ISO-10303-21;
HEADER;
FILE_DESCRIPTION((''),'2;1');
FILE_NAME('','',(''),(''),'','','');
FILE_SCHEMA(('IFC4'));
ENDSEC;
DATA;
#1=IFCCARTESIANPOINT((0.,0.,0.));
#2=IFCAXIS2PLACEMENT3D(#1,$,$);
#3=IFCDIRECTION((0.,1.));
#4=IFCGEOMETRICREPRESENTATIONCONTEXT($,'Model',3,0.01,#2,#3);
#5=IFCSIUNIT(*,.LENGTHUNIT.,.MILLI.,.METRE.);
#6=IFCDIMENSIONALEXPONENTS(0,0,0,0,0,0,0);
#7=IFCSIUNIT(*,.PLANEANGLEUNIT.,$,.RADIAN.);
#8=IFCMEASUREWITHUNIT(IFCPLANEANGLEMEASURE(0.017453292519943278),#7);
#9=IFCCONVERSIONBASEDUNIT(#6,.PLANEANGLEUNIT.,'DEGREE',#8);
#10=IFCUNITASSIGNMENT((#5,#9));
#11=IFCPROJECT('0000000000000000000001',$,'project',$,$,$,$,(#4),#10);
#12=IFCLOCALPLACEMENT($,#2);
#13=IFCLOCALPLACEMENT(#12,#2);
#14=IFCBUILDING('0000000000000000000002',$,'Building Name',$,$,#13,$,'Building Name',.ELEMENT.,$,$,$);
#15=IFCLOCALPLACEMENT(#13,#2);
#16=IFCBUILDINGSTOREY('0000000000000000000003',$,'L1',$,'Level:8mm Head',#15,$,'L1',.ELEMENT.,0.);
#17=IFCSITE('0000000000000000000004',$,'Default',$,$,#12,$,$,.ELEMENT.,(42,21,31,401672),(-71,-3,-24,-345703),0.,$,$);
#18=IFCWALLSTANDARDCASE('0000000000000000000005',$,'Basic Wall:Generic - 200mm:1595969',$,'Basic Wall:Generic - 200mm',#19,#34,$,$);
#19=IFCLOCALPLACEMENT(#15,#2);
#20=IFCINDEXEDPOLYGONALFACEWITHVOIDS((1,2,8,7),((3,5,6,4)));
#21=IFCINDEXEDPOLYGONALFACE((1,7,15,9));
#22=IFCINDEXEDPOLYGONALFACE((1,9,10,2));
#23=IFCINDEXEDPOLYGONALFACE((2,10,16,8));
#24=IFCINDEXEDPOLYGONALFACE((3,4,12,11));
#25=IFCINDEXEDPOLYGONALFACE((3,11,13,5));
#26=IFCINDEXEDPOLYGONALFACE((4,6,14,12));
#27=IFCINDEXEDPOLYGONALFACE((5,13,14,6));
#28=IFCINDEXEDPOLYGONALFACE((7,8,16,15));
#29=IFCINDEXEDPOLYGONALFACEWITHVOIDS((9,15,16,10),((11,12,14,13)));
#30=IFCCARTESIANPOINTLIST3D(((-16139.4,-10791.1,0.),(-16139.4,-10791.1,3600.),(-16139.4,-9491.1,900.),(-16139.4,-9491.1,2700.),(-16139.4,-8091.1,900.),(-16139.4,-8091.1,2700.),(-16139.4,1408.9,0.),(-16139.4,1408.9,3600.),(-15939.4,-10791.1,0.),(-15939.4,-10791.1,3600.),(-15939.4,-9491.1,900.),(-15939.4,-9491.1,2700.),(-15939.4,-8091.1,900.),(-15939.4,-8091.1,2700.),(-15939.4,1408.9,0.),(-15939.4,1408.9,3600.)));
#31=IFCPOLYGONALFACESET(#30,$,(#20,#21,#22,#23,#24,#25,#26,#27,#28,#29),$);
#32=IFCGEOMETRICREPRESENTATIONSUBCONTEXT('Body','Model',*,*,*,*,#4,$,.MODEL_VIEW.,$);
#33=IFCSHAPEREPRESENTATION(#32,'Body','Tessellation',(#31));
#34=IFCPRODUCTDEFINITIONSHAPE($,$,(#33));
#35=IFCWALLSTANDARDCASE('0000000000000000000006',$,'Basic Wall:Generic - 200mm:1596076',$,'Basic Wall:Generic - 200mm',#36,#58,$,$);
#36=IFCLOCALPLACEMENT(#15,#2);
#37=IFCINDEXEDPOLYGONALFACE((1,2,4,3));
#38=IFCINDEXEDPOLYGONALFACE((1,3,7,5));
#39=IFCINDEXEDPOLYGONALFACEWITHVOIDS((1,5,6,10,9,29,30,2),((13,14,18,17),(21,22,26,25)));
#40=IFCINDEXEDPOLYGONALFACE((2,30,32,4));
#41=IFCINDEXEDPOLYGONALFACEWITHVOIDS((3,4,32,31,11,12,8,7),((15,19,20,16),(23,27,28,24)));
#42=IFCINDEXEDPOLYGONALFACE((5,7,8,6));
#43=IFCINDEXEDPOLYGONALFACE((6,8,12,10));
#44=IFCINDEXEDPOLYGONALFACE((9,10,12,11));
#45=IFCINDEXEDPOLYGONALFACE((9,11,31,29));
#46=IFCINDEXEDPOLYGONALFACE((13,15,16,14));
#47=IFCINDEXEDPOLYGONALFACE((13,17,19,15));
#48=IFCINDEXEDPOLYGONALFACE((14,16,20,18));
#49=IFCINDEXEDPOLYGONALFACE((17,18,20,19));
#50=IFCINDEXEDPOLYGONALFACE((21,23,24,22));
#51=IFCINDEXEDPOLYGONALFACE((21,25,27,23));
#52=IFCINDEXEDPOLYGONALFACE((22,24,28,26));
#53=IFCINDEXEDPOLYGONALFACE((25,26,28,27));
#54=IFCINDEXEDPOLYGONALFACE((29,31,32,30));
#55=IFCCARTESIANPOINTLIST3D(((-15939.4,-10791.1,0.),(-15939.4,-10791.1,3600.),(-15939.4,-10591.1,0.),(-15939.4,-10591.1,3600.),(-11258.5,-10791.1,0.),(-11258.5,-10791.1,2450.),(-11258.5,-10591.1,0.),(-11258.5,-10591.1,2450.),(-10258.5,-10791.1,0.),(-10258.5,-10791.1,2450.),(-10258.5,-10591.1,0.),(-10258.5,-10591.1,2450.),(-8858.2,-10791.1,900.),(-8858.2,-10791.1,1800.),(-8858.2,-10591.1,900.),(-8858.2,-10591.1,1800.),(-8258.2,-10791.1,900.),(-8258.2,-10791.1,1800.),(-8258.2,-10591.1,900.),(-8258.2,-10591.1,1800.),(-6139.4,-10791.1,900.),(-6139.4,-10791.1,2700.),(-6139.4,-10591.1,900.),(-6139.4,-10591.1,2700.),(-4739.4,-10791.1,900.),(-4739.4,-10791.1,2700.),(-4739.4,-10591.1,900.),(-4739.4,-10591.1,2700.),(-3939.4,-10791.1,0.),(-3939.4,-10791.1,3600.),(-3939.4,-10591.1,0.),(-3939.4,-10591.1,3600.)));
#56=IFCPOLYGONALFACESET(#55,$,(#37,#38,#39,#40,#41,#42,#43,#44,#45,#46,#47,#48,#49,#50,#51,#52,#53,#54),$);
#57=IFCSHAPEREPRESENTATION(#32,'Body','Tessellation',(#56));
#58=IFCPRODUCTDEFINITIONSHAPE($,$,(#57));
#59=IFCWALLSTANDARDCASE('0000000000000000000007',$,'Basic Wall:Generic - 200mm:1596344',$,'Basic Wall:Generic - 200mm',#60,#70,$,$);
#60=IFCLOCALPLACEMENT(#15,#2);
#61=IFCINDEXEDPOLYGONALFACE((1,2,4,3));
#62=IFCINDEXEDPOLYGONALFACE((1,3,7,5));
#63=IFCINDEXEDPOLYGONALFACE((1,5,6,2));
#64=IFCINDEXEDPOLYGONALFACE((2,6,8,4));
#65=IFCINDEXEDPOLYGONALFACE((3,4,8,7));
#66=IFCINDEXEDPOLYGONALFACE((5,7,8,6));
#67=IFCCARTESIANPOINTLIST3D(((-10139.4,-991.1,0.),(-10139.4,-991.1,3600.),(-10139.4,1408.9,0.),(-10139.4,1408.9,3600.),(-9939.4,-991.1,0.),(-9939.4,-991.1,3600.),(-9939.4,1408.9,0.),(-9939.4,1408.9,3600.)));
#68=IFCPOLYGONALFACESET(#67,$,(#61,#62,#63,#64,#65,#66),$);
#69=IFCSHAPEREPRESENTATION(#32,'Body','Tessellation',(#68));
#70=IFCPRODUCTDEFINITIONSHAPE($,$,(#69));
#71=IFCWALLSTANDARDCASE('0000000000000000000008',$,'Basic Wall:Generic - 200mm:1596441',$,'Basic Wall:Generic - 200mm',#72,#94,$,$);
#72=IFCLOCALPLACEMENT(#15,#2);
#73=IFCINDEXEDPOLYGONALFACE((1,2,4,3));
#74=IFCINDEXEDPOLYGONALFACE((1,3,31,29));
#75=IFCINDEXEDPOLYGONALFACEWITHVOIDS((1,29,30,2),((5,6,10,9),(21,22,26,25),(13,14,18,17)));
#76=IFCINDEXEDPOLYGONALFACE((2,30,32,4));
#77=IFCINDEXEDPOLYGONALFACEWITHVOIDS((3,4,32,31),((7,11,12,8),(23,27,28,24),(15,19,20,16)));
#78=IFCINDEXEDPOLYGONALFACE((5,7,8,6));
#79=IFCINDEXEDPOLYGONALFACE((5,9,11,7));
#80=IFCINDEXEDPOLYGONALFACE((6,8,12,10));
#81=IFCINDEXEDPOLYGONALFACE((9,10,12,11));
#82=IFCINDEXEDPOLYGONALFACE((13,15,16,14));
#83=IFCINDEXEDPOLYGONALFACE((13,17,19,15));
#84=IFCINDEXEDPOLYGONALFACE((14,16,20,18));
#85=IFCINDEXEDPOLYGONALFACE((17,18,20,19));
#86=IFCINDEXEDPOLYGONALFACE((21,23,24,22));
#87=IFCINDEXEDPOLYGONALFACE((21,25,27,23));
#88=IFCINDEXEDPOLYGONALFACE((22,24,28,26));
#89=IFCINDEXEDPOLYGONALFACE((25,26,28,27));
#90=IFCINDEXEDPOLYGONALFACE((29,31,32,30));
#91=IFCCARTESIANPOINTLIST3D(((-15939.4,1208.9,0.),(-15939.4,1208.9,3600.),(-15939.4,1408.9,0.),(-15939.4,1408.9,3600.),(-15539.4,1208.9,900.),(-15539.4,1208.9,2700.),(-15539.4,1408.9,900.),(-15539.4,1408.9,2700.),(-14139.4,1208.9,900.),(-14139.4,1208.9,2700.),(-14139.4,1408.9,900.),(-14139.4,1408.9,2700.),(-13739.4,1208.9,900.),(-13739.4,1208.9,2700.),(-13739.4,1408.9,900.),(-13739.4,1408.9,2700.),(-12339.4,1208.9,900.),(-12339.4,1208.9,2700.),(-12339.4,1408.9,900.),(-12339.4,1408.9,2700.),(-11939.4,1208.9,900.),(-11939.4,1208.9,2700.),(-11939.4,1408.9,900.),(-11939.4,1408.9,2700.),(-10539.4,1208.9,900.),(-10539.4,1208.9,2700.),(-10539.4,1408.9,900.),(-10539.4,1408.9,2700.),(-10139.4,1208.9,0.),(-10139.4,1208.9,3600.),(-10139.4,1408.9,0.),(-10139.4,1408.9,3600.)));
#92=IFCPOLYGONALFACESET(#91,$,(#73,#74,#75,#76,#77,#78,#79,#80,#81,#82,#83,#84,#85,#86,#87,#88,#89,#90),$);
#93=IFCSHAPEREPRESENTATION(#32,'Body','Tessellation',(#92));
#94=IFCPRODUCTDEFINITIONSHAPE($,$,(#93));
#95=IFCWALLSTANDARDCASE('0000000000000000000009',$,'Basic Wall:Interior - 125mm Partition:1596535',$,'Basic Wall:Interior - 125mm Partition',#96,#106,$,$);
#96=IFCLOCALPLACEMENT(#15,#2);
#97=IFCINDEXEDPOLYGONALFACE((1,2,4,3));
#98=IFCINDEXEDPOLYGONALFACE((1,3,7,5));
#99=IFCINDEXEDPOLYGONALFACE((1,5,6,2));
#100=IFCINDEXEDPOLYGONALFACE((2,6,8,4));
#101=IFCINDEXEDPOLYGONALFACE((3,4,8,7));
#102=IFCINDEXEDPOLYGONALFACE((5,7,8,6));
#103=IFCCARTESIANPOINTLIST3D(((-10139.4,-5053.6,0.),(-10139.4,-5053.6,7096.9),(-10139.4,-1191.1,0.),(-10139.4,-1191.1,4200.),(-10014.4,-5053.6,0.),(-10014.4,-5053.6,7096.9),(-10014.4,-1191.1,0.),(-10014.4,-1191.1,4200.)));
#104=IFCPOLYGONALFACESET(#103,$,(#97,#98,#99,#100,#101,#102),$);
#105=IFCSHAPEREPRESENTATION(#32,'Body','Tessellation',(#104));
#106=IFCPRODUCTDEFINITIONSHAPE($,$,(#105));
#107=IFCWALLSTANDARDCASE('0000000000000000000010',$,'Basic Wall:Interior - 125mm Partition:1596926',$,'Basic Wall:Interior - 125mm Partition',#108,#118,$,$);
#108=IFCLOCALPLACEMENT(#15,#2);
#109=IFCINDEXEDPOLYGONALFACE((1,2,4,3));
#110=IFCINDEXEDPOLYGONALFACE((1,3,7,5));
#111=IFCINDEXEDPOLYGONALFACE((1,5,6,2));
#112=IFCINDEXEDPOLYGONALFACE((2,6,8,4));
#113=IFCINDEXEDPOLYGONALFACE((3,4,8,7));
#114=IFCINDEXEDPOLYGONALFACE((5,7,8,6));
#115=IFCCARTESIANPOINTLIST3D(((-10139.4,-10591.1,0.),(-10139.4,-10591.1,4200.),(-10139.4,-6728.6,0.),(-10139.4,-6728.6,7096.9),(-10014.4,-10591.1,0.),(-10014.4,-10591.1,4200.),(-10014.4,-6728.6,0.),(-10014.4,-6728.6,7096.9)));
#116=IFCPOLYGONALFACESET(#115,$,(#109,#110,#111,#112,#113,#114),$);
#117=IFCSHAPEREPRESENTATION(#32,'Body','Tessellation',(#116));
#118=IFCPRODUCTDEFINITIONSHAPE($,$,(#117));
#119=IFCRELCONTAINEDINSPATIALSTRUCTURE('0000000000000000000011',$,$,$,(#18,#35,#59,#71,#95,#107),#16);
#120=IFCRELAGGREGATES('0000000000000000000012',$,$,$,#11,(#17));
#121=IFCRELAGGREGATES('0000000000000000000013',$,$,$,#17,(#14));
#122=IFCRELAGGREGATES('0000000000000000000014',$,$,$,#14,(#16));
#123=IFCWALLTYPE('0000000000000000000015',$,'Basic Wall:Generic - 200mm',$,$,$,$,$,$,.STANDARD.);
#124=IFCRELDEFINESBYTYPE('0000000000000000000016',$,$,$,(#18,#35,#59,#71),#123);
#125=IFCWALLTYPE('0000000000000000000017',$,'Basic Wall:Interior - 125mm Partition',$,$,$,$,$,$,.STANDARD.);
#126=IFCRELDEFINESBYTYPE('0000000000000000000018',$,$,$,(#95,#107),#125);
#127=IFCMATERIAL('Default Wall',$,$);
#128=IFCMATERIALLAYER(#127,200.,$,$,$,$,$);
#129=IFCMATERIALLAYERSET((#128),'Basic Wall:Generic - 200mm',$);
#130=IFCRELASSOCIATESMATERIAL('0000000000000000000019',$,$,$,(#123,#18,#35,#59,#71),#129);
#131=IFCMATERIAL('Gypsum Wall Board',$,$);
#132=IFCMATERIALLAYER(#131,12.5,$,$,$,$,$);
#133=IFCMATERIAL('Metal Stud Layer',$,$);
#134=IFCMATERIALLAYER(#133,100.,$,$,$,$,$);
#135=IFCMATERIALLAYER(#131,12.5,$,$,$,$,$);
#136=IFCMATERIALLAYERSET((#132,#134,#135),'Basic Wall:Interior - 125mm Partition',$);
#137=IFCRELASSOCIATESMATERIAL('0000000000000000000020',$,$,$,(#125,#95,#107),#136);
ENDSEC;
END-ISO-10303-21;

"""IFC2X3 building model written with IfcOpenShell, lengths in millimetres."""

from ifc_helpers import new_model, entity, si_unit, converted_unit, direction, frame, frame_2d, origin, place, context, subcontext, project, spatial, polyline, rectangle, extrude, clip, bounded_halfspace, material, layer, layer_set, layer_usage, type_object, element, save


model = new_model("IFC2X3")

# Units and contexts
model_context = context("Model", 3, precision=0.01, world=origin(), true_north=direction((0.0, 1.0)))
body_context = subcontext(model_context, "Body", "Model", "MODEL_VIEW")
ifc_project = project(units=[si_unit("LENGTHUNIT", "METRE", prefix="MILLI"), converted_unit("PLANEANGLEUNIT", "DEGREE", entity("IfcPlaneAngleMeasure", 0.017453292519943278), si_unit("PLANEANGLEUNIT", "RADIAN"), dimensions=[0, 0, 0, 0, 0, 0, 0])], contexts=[model_context])

# Site, building, storey
site_placement = place(None, origin())
site = spatial("IfcSite", under=ifc_project, at=site_placement, Name="Default", CompositionType="ELEMENT", RefLatitude=(42, 21, 31, 401672), RefLongitude=(-71, -3, -24, -345703), RefElevation=0.0)
building_placement = place(site_placement, origin())
building = spatial("IfcBuilding", under=site, at=building_placement, Name="Building Name", LongName="Building Name", CompositionType="ELEMENT")
storey_placement = place(building_placement, origin())
storey = spatial("IfcBuildingStorey", under=building, at=storey_placement, Name="L1", ObjectType="Level:8mm Head", LongName="L1", CompositionType="ELEMENT", Elevation=0.0)

# Wall, opening
ifc_material_1 = material(Name="Default Wall")
ifc_layer_1 = layer(ifc_material_1, 200.0)
ifc_layer_set_1 = layer_set([ifc_layer_1], Name="Basic Wall:Generic - 200mm")
ifc_layer_usage_1 = layer_usage(ifc_layer_set_1, "AXIS2", "NEGATIVE", 100.0)
wall_type_1 = type_object("IfcWallType", Name="Basic Wall:Generic - 200mm", PredefinedType="STANDARD", material=ifc_layer_set_1)
wall_1_placement = place(storey_placement, frame((-16039.4, 1408.9, 0.0), z_axis=(0.0, 0.0, 1.0), x_axis=(0.0, -1.0, 0.0)))
wall_1 = element("IfcWallStandardCase", 1, at=wall_1_placement, inside=storey, type_object=wall_type_1, material=ifc_layer_usage_1, Name="Basic Wall:Generic - 200mm:1595969", ObjectType="Basic Wall:Generic - 200mm", context=body_context, shape_type="SweptSolid", body=[
    extrude(rectangle(XDim=12200.0, YDim=200.0, at=frame_2d((6100.0, 0.0), x_axis=(-1.0, 0.0))), origin(), (0.0, 0.0, 1.0), 3600.0),
])
opening_1_placement = place(wall_1_placement, frame((10900.0, 100.0, 900.0)))
element("IfcOpeningElement", 2, at=opening_1_placement, cuts=wall_1, ObjectType="Opening", context=body_context, shape_type="SweptSolid", body=[
    extrude(rectangle(XDim=1800.0, YDim=1400.0, at=frame_2d((900.0, 700.0), x_axis=(-1.0, 0.0))), frame((0.0, 0.0, 0.0), z_axis=(0.0, -1.0, 0.0), x_axis=(0.0, 0.0, 1.0)), (0.0, 0.0, 1.0), 200.0),
])

# Wall, openings
wall_2_placement = place(storey_placement, frame((-15939.4, -10691.1, 0.0)))
wall_2 = element("IfcWallStandardCase", 3, at=wall_2_placement, inside=storey, type_object=wall_type_1, material=ifc_layer_usage_1, Name="Basic Wall:Generic - 200mm:1596076", ObjectType="Basic Wall:Generic - 200mm", context=body_context, shape_type="SweptSolid", body=[
    extrude(rectangle(XDim=12000.0, YDim=200.0, at=frame_2d((6000.0, 0.0), x_axis=(1.0, 0.0))), origin(), (0.0, 0.0, 1.0), 3600.0),
])
opening_2_placement = place(wall_2_placement, frame((4680.9, -100.0, 0.0)))
element("IfcOpeningElement", 4, at=opening_2_placement, cuts=wall_2, ObjectType="Opening", context=body_context, shape_type="SweptSolid", body=[
    extrude(rectangle(XDim=2450.0, YDim=1000.0, at=frame_2d((1225.0, 500.0), x_axis=(1.0, 0.0))), frame((0.0, 0.0, 0.0), z_axis=(0.0, 1.0, 0.0), x_axis=(0.0, 0.0, 1.0)), (0.0, 0.0, 1.0), 200.0),
])
opening_3_placement = place(wall_2_placement, frame((11200.0, 100.0, 900.0)))
element("IfcOpeningElement", 5, at=opening_3_placement, cuts=wall_2, ObjectType="Opening", context=body_context, shape_type="SweptSolid", body=[
    extrude(rectangle(XDim=1800.0, YDim=1400.0, at=frame_2d((900.0, 700.0), x_axis=(-1.0, 0.0))), frame((0.0, 0.0, 0.0), z_axis=(0.0, -1.0, 0.0), x_axis=(0.0, 0.0, 1.0)), (0.0, 0.0, 1.0), 200.0),
])
opening_4_placement = place(wall_2_placement, frame((7081.2, -100.0, 900.0)))
element("IfcOpeningElement", 6, at=opening_4_placement, cuts=wall_2, ObjectType="Opening", context=body_context, shape_type="SweptSolid", body=[
    extrude(rectangle(XDim=900.0, YDim=600.0, at=frame_2d((450.0, 300.0), x_axis=(-1.0, 0.0))), frame((0.0, 0.0, 0.0), z_axis=(0.0, 1.0, 0.0), x_axis=(0.0, 0.0, 1.0)), (0.0, 0.0, 1.0), 200.0),
])

# Wall
wall_3_placement = place(storey_placement, frame((-10039.4, -991.1, 0.0), z_axis=(0.0, 0.0, 1.0), x_axis=(0.0, 1.0, 0.0)))
element("IfcWallStandardCase", 7, at=wall_3_placement, inside=storey, type_object=wall_type_1, material=ifc_layer_usage_1, Name="Basic Wall:Generic - 200mm:1596344", ObjectType="Basic Wall:Generic - 200mm", context=body_context, shape_type="SweptSolid", body=[
    extrude(rectangle(XDim=2400.0, YDim=200.0, at=frame_2d((1200.0, 0.0), x_axis=(-1.0, 0.0))), origin(), (0.0, 0.0, 1.0), 3600.0),
])

# Wall, openings
wall_4_placement = place(storey_placement, frame((-10139.4, 1308.9, 0.0), z_axis=(0.0, 0.0, 1.0), x_axis=(-1.0, 0.0, 0.0)))
wall_4 = element("IfcWallStandardCase", 8, at=wall_4_placement, inside=storey, type_object=wall_type_1, material=ifc_layer_usage_1, Name="Basic Wall:Generic - 200mm:1596441", ObjectType="Basic Wall:Generic - 200mm", context=body_context, shape_type="SweptSolid", body=[
    extrude(rectangle(XDim=5800.0, YDim=200.0, at=frame_2d((2900.0, 0.0), x_axis=(-1.0, 0.0))), origin(), (0.0, 0.0, 1.0), 3600.0),
])
opening_5_placement = place(wall_4_placement, frame((3600.0, 100.0, 900.0)))
element("IfcOpeningElement", 9, at=opening_5_placement, cuts=wall_4, ObjectType="Opening", context=body_context, shape_type="SweptSolid", body=[
    extrude(rectangle(XDim=1800.0, YDim=1400.0, at=frame_2d((900.0, 700.0), x_axis=(-1.0, 0.0))), frame((0.0, 0.0, 0.0), z_axis=(0.0, -1.0, 0.0), x_axis=(0.0, 0.0, 1.0)), (0.0, 0.0, 1.0), 200.0),
])
opening_6_placement = place(wall_4_placement, frame((1800.0, 100.0, 900.0)))
element("IfcOpeningElement", 10, at=opening_6_placement, cuts=wall_4, ObjectType="Opening", context=body_context, shape_type="SweptSolid", body=[
    extrude(rectangle(XDim=1800.0, YDim=1400.0, at=frame_2d((900.0, 700.0), x_axis=(-1.0, 0.0))), frame((0.0, 0.0, 0.0), z_axis=(0.0, -1.0, 0.0), x_axis=(0.0, 0.0, 1.0)), (0.0, 0.0, 1.0), 200.0),
])
opening_7_placement = place(wall_4_placement, frame((5400.0, 100.0, 900.0)))
element("IfcOpeningElement", 11, at=opening_7_placement, cuts=wall_4, ObjectType="Opening", context=body_context, shape_type="SweptSolid", body=[
    extrude(rectangle(XDim=1800.0, YDim=1400.0, at=frame_2d((900.0, 700.0), x_axis=(-1.0, 0.0))), frame((0.0, 0.0, 0.0), z_axis=(0.0, -1.0, 0.0), x_axis=(0.0, 0.0, 1.0)), (0.0, 0.0, 1.0), 200.0),
])

# Walls
ifc_material_2 = material(Name="Gypsum Wall Board")
ifc_layer_2 = layer(ifc_material_2, 12.5)
ifc_material_3 = material(Name="Metal Stud Layer")
ifc_layer_3 = layer(ifc_material_3, 100.0)
ifc_layer_4 = layer(ifc_material_2, 12.5)
ifc_layer_set_2 = layer_set([ifc_layer_2, ifc_layer_3, ifc_layer_4], Name="Basic Wall:Interior - 125mm Partition")
ifc_layer_usage_2 = layer_usage(ifc_layer_set_2, "AXIS2", "NEGATIVE", 62.5)
wall_type_2 = type_object("IfcWallType", Name="Basic Wall:Interior - 125mm Partition", PredefinedType="STANDARD", material=ifc_layer_set_2)
wall_5_placement = place(storey_placement, frame((-10076.9, -1191.1, 0.0), z_axis=(0.0, 0.0, 1.0), x_axis=(0.0, -1.0, 0.0)))
element("IfcWallStandardCase", 12, at=wall_5_placement, inside=storey, type_object=wall_type_2, material=ifc_layer_usage_2, Name="Basic Wall:Interior - 125mm Partition:1596535", ObjectType="Basic Wall:Interior - 125mm Partition", context=body_context, shape_type="Clipping", body=[
    clip(extrude(rectangle(XDim=3862.5, YDim=125.0, at=frame_2d((1931.3, 0.0), x_axis=(-1.0, 0.0))), origin(), (0.0, 0.0, 1.0), 7096.9), bounded_halfspace(frame((0.0, -62.5, 4200.0), z_axis=(-0.6, 0.0, 0.8), x_axis=(0.0, -1.0, 0.0)), False, frame((0.0, -62.5, 4200.0)), polyline([(0.0, 0.0), (3862.5, 0.0), (3862.5, 125.0), (3737.5, 125.0), (0.0, 125.0), (0.0, 0.0)]))),
])
wall_6_placement = place(storey_placement, frame((-10076.9, -10591.1, 0.0), z_axis=(0.0, 0.0, 1.0), x_axis=(0.0, 1.0, 0.0)))
element("IfcWallStandardCase", 13, at=wall_6_placement, inside=storey, type_object=wall_type_2, material=ifc_layer_usage_2, Name="Basic Wall:Interior - 125mm Partition:1596926", ObjectType="Basic Wall:Interior - 125mm Partition", context=body_context, shape_type="Clipping", body=[
    clip(extrude(rectangle(XDim=3862.5, YDim=125.0, at=frame_2d((1931.3, 0.0), x_axis=(-1.0, 0.0))), origin(), (0.0, 0.0, 1.0), 7096.9), bounded_halfspace(frame((0.0, -62.5, 4200.0), z_axis=(-0.6, 0.0, 0.8), x_axis=(0.0, -1.0, 0.0)), False, frame((0.0, -62.5, 4200.0)), polyline([(0.0, 0.0), (3737.5, 0.0), (3862.5, 0.0), (3862.5, 125.0), (0.0, 125.0), (0.0, 0.0)]))),
])

save(model, "model.ifc")
